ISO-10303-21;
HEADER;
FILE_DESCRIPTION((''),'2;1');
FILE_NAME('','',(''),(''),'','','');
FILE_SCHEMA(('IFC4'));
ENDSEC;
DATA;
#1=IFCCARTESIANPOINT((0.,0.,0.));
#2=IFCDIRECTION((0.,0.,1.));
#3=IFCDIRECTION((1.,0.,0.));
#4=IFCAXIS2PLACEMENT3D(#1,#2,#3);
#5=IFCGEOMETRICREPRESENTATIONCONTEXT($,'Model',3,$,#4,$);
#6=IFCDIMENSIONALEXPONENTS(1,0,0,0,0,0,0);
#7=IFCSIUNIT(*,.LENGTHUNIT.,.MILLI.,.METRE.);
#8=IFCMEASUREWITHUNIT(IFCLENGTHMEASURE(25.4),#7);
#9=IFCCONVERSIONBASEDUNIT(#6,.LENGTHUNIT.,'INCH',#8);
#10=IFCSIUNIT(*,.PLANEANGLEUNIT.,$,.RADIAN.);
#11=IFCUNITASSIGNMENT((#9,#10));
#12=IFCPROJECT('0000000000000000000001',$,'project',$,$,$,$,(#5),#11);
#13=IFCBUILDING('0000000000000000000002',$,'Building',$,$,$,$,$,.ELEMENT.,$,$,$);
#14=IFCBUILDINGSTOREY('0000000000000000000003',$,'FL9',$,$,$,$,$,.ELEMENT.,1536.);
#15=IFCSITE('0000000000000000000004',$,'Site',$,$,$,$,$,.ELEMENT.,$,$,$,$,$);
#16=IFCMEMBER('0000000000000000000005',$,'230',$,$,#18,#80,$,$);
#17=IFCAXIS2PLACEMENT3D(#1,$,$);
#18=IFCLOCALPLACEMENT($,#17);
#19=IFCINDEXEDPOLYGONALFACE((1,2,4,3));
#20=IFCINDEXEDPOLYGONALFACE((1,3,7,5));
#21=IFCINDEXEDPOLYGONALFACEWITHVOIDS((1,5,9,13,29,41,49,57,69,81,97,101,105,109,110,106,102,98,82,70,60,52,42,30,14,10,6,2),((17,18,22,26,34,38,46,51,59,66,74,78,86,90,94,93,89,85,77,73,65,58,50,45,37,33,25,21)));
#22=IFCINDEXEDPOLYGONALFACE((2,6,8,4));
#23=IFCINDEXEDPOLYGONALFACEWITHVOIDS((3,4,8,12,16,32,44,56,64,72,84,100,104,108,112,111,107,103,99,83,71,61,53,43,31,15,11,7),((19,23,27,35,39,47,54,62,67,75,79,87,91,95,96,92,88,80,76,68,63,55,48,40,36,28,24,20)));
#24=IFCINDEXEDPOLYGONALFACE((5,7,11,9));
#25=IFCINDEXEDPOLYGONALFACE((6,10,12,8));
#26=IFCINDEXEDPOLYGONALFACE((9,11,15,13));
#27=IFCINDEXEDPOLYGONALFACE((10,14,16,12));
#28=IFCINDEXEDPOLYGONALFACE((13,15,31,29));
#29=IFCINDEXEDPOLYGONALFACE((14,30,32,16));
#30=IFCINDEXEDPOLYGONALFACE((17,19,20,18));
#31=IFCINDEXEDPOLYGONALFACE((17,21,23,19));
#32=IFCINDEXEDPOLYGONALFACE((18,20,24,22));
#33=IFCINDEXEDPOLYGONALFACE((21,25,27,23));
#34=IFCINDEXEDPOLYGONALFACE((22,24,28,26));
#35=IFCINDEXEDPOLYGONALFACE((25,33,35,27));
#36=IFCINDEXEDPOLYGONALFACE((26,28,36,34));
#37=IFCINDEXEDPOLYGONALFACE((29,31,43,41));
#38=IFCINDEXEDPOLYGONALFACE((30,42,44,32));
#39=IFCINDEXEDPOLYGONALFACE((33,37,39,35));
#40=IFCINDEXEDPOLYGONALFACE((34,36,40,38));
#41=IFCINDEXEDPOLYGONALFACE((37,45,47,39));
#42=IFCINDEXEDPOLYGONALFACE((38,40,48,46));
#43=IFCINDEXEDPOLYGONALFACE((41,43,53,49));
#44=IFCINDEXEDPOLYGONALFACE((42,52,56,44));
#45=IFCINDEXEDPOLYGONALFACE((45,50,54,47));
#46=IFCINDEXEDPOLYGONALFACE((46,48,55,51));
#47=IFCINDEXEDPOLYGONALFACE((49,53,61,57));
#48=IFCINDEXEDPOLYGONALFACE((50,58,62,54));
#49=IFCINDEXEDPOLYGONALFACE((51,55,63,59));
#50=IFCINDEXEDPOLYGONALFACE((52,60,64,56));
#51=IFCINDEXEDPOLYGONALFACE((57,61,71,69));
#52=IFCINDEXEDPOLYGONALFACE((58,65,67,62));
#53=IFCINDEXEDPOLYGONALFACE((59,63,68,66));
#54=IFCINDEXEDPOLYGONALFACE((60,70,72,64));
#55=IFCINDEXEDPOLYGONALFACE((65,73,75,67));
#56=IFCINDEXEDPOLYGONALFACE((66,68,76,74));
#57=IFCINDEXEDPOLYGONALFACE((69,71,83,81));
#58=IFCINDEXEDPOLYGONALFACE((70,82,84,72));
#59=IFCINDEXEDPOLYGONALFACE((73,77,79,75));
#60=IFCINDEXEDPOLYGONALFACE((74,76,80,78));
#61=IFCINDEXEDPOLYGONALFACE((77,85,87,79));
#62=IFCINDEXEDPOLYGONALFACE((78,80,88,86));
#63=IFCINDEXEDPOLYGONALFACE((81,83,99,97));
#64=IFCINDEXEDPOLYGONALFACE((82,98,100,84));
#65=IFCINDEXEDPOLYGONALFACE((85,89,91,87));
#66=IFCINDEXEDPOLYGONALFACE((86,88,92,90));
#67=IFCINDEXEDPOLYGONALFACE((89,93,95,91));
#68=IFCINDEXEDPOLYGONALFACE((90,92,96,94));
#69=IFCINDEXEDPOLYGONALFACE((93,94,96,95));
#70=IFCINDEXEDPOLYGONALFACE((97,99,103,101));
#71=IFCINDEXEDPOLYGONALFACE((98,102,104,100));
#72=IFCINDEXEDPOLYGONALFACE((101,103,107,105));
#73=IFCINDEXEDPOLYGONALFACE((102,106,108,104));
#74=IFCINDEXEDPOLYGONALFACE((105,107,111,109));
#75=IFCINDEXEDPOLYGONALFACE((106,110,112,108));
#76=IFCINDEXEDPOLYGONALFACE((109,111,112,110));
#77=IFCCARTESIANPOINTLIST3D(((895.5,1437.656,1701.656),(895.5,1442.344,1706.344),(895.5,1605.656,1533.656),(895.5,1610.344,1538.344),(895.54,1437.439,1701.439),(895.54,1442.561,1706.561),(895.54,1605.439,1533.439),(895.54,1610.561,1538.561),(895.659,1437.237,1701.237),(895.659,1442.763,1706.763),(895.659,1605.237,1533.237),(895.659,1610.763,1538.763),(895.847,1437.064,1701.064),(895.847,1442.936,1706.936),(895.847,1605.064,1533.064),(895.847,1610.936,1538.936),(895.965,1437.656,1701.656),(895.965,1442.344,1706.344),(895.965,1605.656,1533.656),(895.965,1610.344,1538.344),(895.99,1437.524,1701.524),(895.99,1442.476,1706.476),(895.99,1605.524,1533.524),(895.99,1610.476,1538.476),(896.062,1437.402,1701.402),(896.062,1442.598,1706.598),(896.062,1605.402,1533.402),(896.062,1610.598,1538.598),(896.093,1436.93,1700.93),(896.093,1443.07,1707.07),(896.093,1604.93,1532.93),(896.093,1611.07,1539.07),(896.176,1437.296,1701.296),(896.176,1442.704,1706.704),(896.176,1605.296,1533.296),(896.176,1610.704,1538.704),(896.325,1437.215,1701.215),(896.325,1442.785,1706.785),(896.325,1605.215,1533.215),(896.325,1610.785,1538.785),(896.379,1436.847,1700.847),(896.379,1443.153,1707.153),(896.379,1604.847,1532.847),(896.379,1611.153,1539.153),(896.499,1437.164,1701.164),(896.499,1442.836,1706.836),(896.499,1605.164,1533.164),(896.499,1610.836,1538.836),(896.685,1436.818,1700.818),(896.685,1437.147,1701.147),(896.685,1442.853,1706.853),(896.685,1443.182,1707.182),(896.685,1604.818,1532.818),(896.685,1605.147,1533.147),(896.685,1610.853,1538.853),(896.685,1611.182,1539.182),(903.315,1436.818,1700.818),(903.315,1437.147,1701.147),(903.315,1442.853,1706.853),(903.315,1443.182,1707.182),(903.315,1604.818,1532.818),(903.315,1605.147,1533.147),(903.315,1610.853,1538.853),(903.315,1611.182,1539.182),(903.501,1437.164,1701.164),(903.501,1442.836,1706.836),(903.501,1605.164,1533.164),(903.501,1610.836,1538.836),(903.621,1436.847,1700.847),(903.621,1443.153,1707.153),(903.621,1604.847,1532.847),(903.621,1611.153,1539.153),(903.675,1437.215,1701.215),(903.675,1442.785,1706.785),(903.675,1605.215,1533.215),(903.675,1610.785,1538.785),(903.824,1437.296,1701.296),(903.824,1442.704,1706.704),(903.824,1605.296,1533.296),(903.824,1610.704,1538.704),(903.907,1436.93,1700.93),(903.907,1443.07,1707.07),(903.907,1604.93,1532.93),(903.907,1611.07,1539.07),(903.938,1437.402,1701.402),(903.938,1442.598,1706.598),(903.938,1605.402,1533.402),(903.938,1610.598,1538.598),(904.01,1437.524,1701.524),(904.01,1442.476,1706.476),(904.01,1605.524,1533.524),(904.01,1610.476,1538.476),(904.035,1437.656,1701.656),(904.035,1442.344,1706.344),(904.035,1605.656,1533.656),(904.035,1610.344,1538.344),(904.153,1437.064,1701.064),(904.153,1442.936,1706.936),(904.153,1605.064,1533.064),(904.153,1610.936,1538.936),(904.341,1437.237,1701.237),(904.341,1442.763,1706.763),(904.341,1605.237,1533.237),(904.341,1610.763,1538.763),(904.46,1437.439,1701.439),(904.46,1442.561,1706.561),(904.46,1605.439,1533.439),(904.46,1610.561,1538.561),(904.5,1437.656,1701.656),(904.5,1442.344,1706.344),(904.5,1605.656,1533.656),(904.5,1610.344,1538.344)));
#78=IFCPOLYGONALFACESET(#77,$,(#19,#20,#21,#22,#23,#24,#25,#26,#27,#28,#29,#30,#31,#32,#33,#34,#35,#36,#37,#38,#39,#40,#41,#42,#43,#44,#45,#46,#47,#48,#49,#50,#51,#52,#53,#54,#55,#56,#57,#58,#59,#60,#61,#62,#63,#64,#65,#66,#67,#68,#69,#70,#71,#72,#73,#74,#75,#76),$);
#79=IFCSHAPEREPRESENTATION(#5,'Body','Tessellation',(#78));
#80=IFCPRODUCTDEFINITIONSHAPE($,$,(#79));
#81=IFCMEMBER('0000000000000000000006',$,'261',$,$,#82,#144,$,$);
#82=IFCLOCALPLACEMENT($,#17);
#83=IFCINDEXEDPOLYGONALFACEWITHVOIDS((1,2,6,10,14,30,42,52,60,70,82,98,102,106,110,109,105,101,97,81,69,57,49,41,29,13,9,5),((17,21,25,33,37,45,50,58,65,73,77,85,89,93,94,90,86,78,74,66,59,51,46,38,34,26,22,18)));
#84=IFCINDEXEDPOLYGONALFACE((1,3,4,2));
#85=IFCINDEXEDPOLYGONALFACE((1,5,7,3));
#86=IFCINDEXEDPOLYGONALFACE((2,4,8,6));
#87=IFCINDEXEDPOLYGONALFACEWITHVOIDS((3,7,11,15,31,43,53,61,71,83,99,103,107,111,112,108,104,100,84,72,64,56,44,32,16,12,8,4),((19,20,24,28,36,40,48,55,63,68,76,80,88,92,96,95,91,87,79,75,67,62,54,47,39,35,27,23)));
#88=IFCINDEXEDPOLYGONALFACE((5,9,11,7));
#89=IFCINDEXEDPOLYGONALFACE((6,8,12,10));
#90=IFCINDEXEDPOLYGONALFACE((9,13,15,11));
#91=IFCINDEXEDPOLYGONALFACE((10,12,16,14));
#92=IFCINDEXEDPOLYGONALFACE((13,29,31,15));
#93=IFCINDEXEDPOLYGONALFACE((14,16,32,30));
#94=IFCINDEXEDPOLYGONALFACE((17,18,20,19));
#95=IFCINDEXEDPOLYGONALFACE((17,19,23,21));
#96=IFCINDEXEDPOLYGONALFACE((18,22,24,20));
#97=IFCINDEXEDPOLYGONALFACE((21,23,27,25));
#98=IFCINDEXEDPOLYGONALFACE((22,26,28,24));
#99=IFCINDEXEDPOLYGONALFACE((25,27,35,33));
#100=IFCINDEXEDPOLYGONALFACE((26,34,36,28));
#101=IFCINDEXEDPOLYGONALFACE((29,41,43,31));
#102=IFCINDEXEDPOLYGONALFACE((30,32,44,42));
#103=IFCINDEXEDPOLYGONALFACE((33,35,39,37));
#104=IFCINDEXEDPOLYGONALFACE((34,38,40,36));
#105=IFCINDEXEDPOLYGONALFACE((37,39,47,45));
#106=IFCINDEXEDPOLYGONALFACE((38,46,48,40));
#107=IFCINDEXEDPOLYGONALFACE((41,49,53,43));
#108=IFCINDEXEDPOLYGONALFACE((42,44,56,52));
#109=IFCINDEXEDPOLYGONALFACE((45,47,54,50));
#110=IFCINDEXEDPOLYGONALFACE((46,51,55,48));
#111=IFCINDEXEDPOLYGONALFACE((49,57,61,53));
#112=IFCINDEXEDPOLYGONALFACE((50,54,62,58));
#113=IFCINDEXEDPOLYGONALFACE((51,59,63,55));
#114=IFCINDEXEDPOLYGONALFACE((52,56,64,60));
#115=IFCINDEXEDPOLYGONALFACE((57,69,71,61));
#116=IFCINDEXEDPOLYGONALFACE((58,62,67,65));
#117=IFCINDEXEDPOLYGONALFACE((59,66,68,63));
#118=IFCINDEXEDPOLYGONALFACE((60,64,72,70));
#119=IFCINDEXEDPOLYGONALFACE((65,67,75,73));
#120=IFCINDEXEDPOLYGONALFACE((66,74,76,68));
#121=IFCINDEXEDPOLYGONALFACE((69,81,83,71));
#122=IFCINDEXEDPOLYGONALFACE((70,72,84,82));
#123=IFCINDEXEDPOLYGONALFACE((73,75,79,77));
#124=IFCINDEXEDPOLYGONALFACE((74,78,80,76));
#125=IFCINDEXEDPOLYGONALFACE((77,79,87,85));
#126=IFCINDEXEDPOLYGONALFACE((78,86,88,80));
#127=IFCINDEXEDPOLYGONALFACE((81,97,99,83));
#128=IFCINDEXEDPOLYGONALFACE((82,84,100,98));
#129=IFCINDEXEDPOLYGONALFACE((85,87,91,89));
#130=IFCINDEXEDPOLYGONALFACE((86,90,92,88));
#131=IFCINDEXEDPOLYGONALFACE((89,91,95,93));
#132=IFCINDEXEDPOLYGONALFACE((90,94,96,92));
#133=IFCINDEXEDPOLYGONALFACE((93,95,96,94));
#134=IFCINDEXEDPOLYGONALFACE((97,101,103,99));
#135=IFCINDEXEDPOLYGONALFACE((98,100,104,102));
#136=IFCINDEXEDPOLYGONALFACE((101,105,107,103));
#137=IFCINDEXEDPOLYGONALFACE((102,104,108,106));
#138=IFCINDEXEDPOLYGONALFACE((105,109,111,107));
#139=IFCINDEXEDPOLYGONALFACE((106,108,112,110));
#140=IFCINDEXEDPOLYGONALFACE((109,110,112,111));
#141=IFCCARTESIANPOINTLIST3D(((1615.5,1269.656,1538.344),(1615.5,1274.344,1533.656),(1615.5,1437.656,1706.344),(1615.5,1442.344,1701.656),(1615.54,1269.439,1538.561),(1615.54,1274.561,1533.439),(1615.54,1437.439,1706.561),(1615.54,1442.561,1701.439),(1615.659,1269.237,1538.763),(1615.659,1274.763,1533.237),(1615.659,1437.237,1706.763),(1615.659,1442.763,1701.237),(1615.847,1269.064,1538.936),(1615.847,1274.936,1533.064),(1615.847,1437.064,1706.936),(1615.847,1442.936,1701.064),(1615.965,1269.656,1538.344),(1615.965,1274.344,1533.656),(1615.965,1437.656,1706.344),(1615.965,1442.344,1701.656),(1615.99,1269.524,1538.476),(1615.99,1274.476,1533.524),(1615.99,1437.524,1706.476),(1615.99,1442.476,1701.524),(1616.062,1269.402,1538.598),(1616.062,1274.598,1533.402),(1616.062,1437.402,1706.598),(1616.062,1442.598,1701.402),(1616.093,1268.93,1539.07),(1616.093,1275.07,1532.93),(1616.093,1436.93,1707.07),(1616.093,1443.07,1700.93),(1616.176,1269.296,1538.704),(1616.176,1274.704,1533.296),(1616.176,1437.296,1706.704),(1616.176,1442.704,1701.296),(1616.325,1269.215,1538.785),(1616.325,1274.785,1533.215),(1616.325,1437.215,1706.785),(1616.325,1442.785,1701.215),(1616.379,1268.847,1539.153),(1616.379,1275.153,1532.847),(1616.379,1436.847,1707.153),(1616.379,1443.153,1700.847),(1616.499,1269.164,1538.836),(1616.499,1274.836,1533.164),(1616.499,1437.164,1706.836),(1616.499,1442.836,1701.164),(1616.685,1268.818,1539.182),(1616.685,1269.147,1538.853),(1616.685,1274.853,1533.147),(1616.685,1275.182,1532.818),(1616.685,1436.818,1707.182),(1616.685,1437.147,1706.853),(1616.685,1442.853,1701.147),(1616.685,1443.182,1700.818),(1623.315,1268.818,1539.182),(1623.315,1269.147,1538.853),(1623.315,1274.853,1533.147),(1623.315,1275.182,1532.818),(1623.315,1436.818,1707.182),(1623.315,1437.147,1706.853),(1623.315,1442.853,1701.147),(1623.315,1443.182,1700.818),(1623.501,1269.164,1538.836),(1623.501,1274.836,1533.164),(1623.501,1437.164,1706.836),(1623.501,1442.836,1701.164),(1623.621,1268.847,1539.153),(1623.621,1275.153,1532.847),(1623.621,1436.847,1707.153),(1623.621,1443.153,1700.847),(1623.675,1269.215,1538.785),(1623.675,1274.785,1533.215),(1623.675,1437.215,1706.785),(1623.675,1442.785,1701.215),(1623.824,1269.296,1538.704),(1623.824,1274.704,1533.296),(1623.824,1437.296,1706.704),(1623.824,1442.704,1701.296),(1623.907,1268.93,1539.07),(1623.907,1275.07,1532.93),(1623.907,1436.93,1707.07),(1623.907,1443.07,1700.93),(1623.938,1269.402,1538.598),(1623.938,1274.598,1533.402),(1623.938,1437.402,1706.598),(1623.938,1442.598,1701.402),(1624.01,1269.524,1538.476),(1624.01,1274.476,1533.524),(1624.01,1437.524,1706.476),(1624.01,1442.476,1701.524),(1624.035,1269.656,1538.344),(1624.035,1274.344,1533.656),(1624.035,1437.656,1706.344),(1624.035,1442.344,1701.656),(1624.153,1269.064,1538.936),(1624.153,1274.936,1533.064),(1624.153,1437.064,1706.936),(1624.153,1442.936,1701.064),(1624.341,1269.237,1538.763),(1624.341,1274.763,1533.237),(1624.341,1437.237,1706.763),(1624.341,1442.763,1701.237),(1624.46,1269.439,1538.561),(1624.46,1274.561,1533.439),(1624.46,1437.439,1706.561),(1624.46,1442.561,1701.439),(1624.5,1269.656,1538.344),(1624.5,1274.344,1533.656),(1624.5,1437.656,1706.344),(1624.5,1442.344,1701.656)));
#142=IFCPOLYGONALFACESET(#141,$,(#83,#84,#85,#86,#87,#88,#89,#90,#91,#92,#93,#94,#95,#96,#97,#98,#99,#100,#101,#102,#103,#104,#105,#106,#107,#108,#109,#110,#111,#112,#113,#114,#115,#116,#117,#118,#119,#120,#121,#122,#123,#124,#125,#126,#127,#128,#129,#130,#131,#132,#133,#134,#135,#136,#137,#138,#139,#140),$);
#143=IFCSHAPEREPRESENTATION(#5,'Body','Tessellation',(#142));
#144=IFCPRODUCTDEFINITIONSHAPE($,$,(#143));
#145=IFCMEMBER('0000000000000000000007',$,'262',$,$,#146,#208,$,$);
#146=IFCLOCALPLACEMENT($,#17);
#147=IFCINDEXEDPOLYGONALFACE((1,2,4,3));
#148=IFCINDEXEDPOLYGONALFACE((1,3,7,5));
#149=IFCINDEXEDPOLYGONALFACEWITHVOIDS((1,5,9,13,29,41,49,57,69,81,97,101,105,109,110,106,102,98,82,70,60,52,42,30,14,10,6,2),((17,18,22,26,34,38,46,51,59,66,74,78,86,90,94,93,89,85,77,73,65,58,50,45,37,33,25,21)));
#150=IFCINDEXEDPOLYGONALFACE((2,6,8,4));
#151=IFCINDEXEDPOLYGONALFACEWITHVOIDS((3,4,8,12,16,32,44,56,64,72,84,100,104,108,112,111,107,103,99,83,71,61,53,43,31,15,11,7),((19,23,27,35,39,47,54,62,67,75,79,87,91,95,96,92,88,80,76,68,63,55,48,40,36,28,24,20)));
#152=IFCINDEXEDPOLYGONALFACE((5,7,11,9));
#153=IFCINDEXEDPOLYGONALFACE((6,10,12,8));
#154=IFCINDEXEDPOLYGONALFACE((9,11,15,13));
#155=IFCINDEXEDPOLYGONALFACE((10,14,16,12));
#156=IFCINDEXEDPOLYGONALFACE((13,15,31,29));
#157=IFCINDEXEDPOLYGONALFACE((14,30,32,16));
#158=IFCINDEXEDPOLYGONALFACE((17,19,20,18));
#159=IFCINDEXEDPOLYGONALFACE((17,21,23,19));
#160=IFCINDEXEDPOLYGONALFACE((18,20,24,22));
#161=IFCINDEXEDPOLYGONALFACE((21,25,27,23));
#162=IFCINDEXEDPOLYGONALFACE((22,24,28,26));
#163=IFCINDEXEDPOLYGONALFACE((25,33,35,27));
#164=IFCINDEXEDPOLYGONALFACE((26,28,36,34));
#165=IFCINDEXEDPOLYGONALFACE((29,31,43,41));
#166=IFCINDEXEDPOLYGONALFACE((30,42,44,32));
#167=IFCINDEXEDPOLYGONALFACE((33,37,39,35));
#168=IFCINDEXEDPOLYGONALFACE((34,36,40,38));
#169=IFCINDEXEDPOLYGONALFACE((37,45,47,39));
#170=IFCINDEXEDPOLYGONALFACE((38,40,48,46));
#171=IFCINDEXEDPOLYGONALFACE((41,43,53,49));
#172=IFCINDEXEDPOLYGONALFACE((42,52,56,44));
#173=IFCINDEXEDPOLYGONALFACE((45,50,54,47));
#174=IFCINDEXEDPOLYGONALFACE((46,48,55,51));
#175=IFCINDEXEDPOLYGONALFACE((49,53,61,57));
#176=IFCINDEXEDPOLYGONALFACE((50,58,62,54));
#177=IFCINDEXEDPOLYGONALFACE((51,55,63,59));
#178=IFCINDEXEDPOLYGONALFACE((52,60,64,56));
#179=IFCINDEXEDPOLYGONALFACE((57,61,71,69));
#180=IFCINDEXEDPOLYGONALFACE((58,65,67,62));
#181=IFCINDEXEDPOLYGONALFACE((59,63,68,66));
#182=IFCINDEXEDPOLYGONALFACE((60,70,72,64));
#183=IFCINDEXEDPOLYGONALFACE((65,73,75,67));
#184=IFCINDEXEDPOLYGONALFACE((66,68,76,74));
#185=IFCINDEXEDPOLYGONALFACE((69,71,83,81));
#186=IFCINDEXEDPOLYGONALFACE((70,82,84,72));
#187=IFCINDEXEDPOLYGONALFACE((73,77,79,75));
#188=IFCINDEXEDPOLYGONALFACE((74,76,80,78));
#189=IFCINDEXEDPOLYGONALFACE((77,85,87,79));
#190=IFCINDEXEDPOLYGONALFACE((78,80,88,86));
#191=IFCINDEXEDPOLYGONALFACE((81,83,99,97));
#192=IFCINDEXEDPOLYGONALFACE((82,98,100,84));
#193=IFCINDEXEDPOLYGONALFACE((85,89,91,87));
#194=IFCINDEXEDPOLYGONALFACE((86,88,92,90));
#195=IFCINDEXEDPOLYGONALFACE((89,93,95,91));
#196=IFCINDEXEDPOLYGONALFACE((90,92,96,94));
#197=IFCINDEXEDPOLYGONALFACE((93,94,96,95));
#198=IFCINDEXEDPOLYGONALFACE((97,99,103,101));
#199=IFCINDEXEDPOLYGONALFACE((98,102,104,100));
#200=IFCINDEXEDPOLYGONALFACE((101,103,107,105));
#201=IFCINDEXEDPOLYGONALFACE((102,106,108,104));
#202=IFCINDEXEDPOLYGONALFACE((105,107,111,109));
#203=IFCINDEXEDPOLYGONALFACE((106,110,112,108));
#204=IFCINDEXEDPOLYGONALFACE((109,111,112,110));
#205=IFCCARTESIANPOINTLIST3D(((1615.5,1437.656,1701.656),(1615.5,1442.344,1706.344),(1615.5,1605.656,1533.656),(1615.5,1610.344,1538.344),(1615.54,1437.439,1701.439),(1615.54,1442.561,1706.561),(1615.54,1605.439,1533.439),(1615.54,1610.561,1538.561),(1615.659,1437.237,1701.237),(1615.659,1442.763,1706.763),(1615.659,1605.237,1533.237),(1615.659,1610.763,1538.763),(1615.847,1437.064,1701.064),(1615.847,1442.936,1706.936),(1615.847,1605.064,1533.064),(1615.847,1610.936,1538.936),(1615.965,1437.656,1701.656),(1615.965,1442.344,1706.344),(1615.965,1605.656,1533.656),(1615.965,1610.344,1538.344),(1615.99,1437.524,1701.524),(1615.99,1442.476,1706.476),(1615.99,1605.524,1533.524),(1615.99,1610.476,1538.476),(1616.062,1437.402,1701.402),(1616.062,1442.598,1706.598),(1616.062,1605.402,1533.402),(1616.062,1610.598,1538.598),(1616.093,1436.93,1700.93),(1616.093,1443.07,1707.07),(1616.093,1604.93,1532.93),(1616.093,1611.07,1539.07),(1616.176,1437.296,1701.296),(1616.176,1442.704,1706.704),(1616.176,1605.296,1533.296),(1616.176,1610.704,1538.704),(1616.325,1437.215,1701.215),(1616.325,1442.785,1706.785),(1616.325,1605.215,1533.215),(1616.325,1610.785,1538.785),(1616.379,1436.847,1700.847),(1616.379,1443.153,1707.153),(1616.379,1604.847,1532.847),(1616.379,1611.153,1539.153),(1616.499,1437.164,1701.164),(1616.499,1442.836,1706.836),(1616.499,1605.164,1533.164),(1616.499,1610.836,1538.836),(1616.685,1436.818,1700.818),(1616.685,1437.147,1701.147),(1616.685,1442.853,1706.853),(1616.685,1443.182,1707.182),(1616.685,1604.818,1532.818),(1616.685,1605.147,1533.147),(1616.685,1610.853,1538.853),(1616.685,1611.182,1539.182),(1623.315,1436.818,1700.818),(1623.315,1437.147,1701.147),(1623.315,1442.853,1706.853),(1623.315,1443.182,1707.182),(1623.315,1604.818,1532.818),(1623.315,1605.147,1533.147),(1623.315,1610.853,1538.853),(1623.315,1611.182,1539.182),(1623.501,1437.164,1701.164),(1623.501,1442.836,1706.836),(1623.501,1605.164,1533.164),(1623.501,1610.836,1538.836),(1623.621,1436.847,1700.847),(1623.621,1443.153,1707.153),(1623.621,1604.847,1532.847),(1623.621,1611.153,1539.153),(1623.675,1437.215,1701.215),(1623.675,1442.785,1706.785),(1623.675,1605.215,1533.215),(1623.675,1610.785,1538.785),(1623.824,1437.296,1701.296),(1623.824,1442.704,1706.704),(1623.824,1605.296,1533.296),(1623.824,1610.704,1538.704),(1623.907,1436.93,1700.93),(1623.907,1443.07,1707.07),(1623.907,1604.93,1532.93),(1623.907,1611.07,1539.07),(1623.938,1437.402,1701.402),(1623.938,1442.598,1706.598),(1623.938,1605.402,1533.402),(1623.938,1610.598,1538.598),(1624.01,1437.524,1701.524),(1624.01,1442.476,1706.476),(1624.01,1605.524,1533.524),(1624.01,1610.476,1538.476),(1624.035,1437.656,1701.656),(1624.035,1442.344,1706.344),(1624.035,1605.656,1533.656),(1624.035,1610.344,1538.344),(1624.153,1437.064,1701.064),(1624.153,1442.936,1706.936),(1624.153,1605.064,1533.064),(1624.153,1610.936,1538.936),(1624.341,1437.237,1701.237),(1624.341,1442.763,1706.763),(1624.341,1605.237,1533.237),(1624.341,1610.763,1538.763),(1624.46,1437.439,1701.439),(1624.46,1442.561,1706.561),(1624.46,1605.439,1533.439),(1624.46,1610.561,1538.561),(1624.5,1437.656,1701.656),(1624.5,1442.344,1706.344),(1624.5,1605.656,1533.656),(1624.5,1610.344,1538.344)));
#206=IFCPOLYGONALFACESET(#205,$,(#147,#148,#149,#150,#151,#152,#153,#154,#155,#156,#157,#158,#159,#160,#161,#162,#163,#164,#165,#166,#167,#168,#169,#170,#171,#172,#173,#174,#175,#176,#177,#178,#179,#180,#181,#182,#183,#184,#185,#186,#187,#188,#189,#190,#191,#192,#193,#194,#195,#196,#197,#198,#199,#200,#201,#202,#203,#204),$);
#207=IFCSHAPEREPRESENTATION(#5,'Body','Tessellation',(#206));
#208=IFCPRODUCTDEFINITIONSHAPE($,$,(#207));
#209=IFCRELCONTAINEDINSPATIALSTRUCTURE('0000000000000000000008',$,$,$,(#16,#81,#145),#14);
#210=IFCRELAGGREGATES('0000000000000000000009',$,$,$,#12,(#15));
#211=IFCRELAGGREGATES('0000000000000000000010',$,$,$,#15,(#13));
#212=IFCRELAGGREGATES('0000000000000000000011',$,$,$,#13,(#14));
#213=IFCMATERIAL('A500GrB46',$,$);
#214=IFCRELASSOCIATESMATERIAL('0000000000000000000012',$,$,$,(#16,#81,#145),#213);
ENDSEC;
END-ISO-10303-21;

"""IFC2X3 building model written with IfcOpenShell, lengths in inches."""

from ifc_helpers import new_model, entity, si_unit, converted_unit, frame, origin_with_axes, origin_2d_with_axis, place, context, project, spatial, hollow_rectangle, extrude, material, element, save


model = new_model("IFC2X3")

# Units and contexts
model_context = context("Model", 3, world=origin_with_axes())
ifc_project = project(units=[converted_unit("LENGTHUNIT", "INCH", entity("IfcLengthMeasure", 25.4), si_unit("LENGTHUNIT", "METRE", prefix="MILLI"), dimensions=[1, 0, 0, 0, 0, 0, 0]), si_unit("PLANEANGLEUNIT", "RADIAN")], contexts=[model_context])

# Site, building, storey
site = spatial("IfcSite", under=ifc_project, Name="Site", CompositionType="ELEMENT")
building = spatial("IfcBuilding", under=site, Name="Building", CompositionType="ELEMENT")
storey = spatial("IfcBuildingStorey", under=building, Name="FL9", CompositionType="ELEMENT", Elevation=1536.0)

# Members
ifc_material_1 = material(Name="A500GrB46")
for number, where, z_axis, x_axis, name in (
    (1, (900.0, 1608.0, 1536.0), (0.0, -0.707107, 0.707107), (1.0, 0.0, 0.0), "230"),
    (2, (1620.0, 1272.0, 1536.0), (0.0, 0.707107, 0.707107), (-1.0, 0.0, 0.0), "261"),
    (3, (1620.0, 1608.0, 1536.0), (0.0, -0.707107, 0.707107), (1.0, 0.0, 0.0), "262"),
):
    element("IfcMember", number, at=place(None, frame(where, z_axis=z_axis, x_axis=x_axis)), inside=storey, material=ifc_material_1, Name=name, context=model_context, shape_type="SweptSolid", body=[
        extrude(hollow_rectangle(XDim=9.0, YDim=9.0, WallThickness=0.465, InnerFilletRadius=0.72, OuterFilletRadius=1.185, at=origin_2d_with_axis()), origin_with_axes(), (0.0, 0.0, 1.0), 237.588),
    ])

save(model, "model.ifc")
